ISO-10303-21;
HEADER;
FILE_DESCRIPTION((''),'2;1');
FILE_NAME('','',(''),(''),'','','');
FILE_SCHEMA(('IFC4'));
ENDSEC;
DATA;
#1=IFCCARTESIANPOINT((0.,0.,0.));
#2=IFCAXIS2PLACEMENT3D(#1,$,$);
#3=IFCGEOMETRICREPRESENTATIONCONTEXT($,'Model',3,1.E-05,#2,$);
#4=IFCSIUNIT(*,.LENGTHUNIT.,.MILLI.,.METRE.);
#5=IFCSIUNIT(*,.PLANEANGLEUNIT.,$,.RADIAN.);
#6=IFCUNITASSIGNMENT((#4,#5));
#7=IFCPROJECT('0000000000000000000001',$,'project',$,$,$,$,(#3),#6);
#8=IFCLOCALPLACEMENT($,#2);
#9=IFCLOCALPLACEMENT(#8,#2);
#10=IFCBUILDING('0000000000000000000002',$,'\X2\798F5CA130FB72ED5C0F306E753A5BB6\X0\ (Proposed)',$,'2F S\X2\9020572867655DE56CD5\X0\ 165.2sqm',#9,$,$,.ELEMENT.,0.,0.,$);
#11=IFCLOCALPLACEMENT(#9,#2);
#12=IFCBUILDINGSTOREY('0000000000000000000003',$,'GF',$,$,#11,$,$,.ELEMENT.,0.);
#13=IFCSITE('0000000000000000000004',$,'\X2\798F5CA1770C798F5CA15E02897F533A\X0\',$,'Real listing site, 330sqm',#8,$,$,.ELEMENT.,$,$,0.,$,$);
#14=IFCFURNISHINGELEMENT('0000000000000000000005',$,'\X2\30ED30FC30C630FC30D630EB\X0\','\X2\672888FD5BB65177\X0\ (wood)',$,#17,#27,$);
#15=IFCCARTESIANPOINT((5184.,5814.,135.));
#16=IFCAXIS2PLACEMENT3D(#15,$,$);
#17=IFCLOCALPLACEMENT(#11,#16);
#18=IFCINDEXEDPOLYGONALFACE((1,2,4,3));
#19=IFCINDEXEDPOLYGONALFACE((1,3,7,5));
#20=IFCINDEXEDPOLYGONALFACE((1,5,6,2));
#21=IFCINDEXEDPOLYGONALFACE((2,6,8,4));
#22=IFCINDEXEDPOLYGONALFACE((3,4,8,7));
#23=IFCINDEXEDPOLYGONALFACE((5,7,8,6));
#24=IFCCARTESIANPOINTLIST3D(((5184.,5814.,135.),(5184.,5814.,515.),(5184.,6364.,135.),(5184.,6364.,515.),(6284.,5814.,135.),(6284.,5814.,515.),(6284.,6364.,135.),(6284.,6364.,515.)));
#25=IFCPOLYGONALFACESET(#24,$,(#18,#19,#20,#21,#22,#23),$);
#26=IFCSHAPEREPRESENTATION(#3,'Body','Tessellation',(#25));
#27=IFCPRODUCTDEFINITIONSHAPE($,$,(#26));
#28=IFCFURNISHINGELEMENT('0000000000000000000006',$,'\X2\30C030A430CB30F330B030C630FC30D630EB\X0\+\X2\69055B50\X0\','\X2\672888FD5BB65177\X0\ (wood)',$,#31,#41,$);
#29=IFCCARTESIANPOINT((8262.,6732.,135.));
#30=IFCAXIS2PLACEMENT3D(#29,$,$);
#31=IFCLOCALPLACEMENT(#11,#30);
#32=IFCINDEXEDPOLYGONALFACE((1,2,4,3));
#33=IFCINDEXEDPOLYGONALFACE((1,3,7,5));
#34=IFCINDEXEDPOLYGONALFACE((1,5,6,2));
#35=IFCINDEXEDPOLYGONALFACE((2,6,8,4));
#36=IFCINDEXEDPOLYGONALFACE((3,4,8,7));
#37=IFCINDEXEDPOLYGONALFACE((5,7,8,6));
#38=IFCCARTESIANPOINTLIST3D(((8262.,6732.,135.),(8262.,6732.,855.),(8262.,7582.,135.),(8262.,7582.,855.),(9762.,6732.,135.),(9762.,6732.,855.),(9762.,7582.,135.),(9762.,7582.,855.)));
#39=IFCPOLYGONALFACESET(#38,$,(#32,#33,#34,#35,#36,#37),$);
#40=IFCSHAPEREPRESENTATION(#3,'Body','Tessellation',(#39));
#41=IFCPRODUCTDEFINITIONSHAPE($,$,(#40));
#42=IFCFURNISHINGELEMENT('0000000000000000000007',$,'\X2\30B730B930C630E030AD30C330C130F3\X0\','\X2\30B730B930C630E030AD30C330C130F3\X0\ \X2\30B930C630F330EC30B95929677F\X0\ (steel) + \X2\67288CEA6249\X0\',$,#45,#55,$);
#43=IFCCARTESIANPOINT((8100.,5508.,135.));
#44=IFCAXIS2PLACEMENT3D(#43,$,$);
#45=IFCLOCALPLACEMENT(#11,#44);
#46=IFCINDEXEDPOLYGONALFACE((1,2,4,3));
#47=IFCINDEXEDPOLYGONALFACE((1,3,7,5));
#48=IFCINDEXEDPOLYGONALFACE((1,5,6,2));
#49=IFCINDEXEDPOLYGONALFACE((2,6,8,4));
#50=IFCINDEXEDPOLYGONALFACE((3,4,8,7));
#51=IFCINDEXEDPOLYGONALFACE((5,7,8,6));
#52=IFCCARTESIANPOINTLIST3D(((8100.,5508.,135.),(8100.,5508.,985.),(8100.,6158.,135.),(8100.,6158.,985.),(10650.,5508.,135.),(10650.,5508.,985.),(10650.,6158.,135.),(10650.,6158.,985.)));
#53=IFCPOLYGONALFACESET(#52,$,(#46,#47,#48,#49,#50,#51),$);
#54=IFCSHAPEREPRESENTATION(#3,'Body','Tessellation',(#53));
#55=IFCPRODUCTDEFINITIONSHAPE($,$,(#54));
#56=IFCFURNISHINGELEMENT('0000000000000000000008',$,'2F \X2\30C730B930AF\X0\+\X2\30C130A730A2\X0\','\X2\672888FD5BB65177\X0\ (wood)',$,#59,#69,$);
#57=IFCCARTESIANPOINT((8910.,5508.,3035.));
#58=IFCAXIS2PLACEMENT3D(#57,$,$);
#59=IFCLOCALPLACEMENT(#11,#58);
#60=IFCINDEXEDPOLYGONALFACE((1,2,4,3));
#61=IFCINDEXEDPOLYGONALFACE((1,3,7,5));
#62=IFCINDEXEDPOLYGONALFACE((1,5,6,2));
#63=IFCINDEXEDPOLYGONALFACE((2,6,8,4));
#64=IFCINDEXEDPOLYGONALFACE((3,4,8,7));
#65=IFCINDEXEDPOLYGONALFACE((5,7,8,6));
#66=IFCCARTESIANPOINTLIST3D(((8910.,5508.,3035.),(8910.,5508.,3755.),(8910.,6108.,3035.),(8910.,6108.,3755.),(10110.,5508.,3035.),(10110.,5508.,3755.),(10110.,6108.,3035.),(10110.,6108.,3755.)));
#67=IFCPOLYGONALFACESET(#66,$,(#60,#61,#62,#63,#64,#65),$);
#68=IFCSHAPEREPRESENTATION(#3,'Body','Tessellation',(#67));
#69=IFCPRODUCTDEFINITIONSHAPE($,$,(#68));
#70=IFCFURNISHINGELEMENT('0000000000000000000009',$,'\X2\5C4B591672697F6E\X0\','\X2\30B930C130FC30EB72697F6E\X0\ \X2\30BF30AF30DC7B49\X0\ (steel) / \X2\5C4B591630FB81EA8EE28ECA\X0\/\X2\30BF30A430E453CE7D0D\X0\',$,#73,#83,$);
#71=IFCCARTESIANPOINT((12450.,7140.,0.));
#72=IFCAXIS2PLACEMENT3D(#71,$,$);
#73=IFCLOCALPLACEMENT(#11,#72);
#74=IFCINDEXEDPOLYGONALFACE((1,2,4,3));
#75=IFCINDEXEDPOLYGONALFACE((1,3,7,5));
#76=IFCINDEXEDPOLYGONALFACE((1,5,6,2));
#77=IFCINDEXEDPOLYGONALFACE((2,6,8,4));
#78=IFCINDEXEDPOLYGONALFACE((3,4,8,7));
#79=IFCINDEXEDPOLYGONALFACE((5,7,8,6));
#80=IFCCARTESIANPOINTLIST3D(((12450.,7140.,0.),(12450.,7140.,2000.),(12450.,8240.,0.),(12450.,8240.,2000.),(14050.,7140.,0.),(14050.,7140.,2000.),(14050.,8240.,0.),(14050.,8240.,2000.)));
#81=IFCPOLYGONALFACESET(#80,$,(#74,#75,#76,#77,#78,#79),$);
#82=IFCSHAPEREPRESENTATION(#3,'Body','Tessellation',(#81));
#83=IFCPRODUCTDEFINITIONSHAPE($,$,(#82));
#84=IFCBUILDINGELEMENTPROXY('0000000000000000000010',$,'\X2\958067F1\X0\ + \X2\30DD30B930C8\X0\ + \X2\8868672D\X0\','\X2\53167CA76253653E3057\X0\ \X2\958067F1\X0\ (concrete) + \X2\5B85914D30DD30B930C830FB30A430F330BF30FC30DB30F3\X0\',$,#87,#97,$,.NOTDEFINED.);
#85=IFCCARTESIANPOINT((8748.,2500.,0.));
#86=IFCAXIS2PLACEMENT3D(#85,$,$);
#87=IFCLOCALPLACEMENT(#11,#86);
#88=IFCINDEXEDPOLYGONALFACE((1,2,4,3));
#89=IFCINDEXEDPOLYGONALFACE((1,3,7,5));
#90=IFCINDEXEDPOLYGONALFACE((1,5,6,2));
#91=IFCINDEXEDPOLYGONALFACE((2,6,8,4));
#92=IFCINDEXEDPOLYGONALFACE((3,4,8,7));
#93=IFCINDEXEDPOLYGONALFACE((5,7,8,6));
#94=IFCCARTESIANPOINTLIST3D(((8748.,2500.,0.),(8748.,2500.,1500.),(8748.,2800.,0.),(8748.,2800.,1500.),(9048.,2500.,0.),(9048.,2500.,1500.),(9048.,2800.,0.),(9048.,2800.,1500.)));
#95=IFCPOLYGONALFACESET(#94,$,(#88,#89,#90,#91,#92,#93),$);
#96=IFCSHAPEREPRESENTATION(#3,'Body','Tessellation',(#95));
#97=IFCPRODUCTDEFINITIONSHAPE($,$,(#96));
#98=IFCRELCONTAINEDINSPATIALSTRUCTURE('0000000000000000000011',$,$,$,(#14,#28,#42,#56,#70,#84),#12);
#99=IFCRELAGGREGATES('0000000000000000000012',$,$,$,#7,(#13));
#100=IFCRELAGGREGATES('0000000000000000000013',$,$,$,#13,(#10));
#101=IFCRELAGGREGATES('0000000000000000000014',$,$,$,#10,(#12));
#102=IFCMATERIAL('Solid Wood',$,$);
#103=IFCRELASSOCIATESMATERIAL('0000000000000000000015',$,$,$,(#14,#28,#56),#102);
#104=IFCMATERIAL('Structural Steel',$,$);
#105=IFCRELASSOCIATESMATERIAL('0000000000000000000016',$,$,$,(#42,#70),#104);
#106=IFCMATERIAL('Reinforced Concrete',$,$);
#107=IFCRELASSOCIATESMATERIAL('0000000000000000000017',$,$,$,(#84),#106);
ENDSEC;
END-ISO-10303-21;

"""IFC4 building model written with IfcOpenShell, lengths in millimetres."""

from ifc_helpers import new_model, si_unit, frame, frame_2d, origin, place, context, project, spatial, rectangle, extrude, material, element, save


model = new_model("IFC4")

# Units and contexts
model_context = context("Model", 3, precision=1e-05, world=origin())
ifc_project = project(units=[si_unit("LENGTHUNIT", "METRE", prefix="MILLI"), si_unit("PLANEANGLEUNIT", "RADIAN")], contexts=[model_context])

# Site, building, storey
site_placement = place(None, origin())
site = spatial("IfcSite", under=ifc_project, at=site_placement, Name="福岡県福岡市西区", ObjectType="Real listing site, 330sqm", CompositionType="ELEMENT", RefElevation=0.0)
building_placement = place(site_placement, origin())
building = spatial("IfcBuilding", under=site, at=building_placement, Name="福岡・狭小の町家 (Proposed)", ObjectType="2F S造在来工法 165.2sqm", CompositionType="ELEMENT", ElevationOfRefHeight=0.0, ElevationOfTerrain=0.0)
storey_placement = place(building_placement, origin())
storey = spatial("IfcBuildingStorey", under=building, at=storey_placement, Name="GF", CompositionType="ELEMENT", Elevation=0.0)

# Shared definitions
ifc_material_1 = material(Name="Solid Wood")

# Shared definitions
ifc_material_2 = material(Name="Reinforced Concrete")

# Shared definitions
ifc_material_3 = material(Name="Structural Steel")

# Furnishing elements
furnishing_1_placement = place(storey_placement, frame((5184.0, 5814.0, 135.0)))
element("IfcFurnishingElement", 1, at=furnishing_1_placement, inside=storey, material=ifc_material_1, Name="ローテーブル", Description="木製家具 (wood)", context=model_context, shape_type="SweptSolid", body=[
    extrude(rectangle(XDim=1100.0, YDim=550.0, at=frame_2d((550.0, 275.0))), frame((5184.0, 5814.0, 135.0)), (0.0, 0.0, 1.0), 380.0),
])
furnishing_2_placement = place(storey_placement, frame((8262.0, 6732.0, 135.0)))
element("IfcFurnishingElement", 2, at=furnishing_2_placement, inside=storey, material=ifc_material_1, Name="ダイニングテーブル+椅子", Description="木製家具 (wood)", context=model_context, shape_type="SweptSolid", body=[
    extrude(rectangle(XDim=1500.0, YDim=850.0, at=frame_2d((750.0, 425.0))), frame((8262.0, 6732.0, 135.0)), (0.0, 0.0, 1.0), 720.0),
])
furnishing_3_placement = place(storey_placement, frame((8100.0, 5508.0, 135.0)))
element("IfcFurnishingElement", 3, at=furnishing_3_placement, inside=storey, material=ifc_material_3, Name="システムキッチン", Description="システムキッチン ステンレス天板 (steel) + 木質扉", context=model_context, shape_type="SweptSolid", body=[
    extrude(rectangle(XDim=2550.0, YDim=650.0, at=frame_2d((1275.0, 325.0))), frame((8100.0, 5508.0, 135.0)), (0.0, 0.0, 1.0), 850.0),
])
furnishing_4_placement = place(storey_placement, frame((8910.0, 5508.0, 3035.0)))
element("IfcFurnishingElement", 4, at=furnishing_4_placement, inside=storey, material=ifc_material_1, Name="2F デスク+チェア", Description="木製家具 (wood)", context=model_context, shape_type="SweptSolid", body=[
    extrude(rectangle(XDim=1200.0, YDim=600.0, at=frame_2d((600.0, 300.0))), frame((8910.0, 5508.0, 3035.0)), (0.0, 0.0, 1.0), 720.0),
])
furnishing_5_placement = place(storey_placement, frame((12450.0, 7140.0, 0.0)))
element("IfcFurnishingElement", 5, at=furnishing_5_placement, inside=storey, material=ifc_material_3, Name="屋外物置", Description="スチール物置 タクボ等 (steel) / 屋外・自転車/タイヤ収納", context=model_context, shape_type="SweptSolid", body=[
    extrude(rectangle(XDim=1600.0, YDim=1100.0, at=frame_2d((800.0, 550.0))), frame((12450.0, 7140.0, 0.0)), (0.0, 0.0, 1.0), 2000.0),
])

# Building element proxy
proxy_placement = place(storey_placement, frame((8748.0, 2500.0, 0.0)))
element("IfcBuildingElementProxy", 6, at=proxy_placement, inside=storey, material=ifc_material_2, Name="門柱 + ポスト + 表札", Description="化粧打放し 門柱 (concrete) + 宅配ポスト・インターホン", PredefinedType="NOTDEFINED", context=model_context, shape_type="SweptSolid", body=[
    extrude(rectangle(XDim=300.0, YDim=300.0, at=frame_2d((150.0, 150.0))), frame((8748.0, 2500.0, 0.0)), (0.0, 0.0, 1.0), 1500.0),
])

save(model, "model.ifc")
